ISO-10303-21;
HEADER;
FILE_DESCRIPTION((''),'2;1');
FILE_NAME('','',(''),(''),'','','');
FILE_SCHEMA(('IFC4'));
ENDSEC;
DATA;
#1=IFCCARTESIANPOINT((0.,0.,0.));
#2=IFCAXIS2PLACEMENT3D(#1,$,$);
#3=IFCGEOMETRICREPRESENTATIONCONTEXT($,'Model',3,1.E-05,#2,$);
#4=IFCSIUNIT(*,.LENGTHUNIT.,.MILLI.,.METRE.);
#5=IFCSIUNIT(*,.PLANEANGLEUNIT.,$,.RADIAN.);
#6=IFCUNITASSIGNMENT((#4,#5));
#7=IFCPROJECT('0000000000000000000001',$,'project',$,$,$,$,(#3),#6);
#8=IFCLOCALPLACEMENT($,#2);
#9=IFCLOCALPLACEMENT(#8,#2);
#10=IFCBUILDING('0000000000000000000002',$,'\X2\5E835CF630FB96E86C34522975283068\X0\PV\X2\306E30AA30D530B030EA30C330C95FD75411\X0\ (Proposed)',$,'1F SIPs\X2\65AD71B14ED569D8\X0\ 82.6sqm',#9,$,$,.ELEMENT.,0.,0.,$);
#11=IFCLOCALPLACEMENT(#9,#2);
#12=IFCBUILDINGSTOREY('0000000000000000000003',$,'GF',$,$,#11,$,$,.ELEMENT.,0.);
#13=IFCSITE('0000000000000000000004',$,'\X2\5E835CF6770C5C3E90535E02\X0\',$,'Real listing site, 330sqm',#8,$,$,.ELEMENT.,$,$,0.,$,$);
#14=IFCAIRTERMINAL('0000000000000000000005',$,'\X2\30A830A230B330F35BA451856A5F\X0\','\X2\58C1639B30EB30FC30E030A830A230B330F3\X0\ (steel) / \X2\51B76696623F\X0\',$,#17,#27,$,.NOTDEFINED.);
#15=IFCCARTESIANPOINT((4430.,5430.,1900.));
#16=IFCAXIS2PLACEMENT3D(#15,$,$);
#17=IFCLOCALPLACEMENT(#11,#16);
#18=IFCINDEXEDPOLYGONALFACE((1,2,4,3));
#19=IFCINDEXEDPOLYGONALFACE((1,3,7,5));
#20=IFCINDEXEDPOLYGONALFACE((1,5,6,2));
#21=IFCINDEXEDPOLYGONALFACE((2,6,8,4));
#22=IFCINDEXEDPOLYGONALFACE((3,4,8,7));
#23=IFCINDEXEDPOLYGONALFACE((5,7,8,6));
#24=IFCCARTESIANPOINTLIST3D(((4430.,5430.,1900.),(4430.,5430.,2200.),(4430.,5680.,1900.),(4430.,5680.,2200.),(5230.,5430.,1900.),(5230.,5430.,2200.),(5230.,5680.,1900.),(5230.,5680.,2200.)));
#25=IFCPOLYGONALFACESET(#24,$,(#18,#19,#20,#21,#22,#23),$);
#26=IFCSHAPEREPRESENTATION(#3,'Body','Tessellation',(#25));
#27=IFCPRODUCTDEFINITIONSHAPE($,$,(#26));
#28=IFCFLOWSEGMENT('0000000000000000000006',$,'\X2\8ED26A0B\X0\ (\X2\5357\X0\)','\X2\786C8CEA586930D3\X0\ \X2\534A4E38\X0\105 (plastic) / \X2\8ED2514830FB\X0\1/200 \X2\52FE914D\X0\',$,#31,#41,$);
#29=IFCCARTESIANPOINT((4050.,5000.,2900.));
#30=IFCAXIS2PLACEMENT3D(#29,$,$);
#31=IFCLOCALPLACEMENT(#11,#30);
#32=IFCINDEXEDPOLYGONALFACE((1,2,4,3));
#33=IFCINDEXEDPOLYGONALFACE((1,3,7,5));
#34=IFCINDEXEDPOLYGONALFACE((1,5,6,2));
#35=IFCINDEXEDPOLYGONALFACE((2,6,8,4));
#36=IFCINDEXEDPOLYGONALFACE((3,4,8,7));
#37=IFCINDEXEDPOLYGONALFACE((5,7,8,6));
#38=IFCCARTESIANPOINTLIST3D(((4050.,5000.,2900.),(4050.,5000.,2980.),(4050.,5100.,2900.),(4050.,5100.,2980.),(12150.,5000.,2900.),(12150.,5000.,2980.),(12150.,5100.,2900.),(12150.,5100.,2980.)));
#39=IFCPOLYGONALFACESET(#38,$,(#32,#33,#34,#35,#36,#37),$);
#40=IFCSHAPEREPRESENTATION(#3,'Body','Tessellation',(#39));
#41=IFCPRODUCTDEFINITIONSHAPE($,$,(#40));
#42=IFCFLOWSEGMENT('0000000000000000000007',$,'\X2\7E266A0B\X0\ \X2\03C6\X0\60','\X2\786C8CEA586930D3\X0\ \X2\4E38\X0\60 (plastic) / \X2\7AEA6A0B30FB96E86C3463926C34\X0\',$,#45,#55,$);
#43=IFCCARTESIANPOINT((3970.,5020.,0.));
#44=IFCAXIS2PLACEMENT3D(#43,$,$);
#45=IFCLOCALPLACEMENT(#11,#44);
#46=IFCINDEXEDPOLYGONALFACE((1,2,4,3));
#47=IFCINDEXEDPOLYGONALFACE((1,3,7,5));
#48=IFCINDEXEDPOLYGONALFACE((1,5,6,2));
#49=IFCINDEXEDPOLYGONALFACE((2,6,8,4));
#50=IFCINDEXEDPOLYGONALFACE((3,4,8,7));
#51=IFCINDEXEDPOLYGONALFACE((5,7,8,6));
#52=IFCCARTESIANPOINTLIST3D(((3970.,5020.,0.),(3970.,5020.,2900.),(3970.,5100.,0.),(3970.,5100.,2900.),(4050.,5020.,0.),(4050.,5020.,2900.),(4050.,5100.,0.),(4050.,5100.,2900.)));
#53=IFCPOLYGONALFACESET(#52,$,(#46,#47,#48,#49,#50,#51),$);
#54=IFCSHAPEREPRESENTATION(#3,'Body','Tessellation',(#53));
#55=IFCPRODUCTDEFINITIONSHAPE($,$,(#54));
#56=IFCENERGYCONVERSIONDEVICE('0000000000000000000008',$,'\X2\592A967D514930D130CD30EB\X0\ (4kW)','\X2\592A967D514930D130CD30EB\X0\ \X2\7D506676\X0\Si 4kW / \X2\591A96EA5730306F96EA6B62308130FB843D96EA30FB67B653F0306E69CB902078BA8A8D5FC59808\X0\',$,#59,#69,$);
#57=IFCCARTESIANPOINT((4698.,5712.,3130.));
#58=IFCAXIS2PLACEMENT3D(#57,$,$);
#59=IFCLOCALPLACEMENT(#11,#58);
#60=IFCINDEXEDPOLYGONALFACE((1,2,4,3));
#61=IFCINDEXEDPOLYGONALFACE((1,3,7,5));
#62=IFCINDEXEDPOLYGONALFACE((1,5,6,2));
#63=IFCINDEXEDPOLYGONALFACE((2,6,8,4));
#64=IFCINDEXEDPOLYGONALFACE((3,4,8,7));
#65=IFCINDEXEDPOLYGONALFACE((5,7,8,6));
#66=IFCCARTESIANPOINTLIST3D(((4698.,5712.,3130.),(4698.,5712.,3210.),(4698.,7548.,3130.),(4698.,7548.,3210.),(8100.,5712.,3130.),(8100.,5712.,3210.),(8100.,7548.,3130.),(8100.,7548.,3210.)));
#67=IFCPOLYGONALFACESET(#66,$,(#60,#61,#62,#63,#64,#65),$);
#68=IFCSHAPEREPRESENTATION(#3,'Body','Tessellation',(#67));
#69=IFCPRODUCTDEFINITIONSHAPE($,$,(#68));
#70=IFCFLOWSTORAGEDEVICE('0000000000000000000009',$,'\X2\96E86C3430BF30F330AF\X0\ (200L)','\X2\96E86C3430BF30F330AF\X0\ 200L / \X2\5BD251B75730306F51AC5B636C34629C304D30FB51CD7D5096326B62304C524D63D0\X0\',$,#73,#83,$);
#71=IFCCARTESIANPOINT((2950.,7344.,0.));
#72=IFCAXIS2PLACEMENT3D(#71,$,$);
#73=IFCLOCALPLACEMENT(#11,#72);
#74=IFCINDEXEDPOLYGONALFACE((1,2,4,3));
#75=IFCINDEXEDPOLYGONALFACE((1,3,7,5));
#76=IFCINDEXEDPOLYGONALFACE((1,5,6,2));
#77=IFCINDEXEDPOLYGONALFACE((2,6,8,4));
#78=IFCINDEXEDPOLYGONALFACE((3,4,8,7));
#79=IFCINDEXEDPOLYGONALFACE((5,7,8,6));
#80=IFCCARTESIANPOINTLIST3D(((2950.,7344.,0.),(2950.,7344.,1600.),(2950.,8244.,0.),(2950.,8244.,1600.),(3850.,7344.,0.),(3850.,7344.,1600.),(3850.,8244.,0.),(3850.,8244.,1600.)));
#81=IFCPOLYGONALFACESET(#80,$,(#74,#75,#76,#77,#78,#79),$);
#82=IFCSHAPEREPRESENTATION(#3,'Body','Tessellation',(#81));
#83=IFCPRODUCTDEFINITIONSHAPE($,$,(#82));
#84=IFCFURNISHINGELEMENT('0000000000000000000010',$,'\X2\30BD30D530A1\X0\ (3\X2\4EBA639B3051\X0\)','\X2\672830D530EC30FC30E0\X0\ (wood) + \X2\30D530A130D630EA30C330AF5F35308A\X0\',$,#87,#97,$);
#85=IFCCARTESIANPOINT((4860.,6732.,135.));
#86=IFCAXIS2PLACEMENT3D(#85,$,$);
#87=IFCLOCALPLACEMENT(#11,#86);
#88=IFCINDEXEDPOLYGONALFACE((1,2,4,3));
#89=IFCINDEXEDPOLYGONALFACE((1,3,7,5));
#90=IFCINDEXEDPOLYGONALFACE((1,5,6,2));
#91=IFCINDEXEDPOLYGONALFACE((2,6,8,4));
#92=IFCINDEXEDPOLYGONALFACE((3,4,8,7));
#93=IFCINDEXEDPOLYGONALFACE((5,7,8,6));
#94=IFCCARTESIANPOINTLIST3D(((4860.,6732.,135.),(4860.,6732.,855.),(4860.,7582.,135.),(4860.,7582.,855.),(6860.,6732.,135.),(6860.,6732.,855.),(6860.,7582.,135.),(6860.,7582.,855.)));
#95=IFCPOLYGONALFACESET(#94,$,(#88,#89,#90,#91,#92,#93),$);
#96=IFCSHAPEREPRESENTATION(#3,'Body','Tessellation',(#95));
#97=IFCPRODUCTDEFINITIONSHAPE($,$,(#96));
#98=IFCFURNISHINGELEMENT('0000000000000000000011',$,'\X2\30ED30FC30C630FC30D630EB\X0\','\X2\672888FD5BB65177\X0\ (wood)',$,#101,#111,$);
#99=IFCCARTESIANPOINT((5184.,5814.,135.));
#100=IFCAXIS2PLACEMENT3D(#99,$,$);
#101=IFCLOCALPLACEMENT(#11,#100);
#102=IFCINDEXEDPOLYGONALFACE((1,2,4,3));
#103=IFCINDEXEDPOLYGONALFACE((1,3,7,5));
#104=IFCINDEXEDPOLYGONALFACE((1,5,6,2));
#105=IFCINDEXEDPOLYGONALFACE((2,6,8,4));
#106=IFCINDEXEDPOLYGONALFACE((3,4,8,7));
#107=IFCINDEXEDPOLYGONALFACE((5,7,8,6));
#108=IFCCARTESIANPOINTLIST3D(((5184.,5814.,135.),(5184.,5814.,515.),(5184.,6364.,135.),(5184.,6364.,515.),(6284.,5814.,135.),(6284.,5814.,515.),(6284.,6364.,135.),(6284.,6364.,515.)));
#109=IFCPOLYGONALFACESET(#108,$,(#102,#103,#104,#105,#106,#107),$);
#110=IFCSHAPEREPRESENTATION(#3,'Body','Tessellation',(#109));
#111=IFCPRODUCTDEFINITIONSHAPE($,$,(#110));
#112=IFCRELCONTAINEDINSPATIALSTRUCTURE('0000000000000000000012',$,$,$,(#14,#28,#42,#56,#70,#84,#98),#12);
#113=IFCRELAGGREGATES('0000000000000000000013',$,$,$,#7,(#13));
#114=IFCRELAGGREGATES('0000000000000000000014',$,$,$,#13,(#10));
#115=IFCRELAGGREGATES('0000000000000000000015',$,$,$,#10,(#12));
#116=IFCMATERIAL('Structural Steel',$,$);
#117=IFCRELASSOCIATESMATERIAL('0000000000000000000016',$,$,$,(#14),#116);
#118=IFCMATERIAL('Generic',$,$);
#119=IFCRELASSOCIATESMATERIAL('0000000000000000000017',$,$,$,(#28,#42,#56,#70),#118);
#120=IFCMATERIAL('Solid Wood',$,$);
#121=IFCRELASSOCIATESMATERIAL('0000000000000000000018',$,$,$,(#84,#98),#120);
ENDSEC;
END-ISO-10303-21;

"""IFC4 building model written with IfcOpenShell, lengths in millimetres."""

from ifc_helpers import new_model, si_unit, frame, frame_2d, origin, place, context, project, spatial, rectangle, extrude, material, element, save


model = new_model("IFC4")

# Units and contexts
model_context = context("Model", 3, precision=1e-05, world=origin())
ifc_project = project(units=[si_unit("LENGTHUNIT", "METRE", prefix="MILLI"), si_unit("PLANEANGLEUNIT", "RADIAN")], contexts=[model_context])

# Site, building, storey
site_placement = place(None, origin())
site = spatial("IfcSite", under=ifc_project, at=site_placement, Name="広島県尾道市", ObjectType="Real listing site, 330sqm", CompositionType="ELEMENT", RefElevation=0.0)
building_placement = place(site_placement, origin())
building = spatial("IfcBuilding", under=site, at=building_placement, Name="広島・雨水利用とPVのオフグリッド志向 (Proposed)", ObjectType="1F SIPs断熱仕様 82.6sqm", CompositionType="ELEMENT", ElevationOfRefHeight=0.0, ElevationOfTerrain=0.0)
storey_placement = place(building_placement, origin())
storey = spatial("IfcBuildingStorey", under=building, at=storey_placement, Name="GF", CompositionType="ELEMENT", Elevation=0.0)

# Shared definitions
ifc_material_1 = material(Name="Solid Wood")

# Shared definitions
ifc_material_2 = material(Name="Structural Steel")

# Shared definitions
ifc_material_3 = material(Name="Generic")

# Air terminal
air_terminal_placement = place(storey_placement, frame((4430.0, 5430.0, 1900.0)))
element("IfcAirTerminal", 1, at=air_terminal_placement, inside=storey, material=ifc_material_2, Name="エアコン室内機", Description="壁掛ルームエアコン (steel) / 冷暖房", PredefinedType="NOTDEFINED", context=model_context, shape_type="SweptSolid", body=[
    extrude(rectangle(XDim=800.0, YDim=250.0, at=frame_2d((400.0, 125.0))), frame((4430.0, 5430.0, 1900.0)), (0.0, 0.0, 1.0), 300.0),
])

# Flow segments
flow_segment_1_placement = place(storey_placement, frame((4050.0, 5000.0, 2900.0)))
element("IfcFlowSegment", 2, at=flow_segment_1_placement, inside=storey, material=ifc_material_3, Name="軒樋 (南)", Description="硬質塩ビ 半丸105 (plastic) / 軒先・1/200 勾配", context=model_context, shape_type="SweptSolid", body=[
    extrude(rectangle(XDim=8100.0, YDim=100.0, at=frame_2d((4050.0, 50.0))), frame((4050.0, 5000.0, 2900.0)), (0.0, 0.0, 1.0), 80.0),
])
flow_segment_2_placement = place(storey_placement, frame((3970.0, 5020.0, 0.0)))
element("IfcFlowSegment", 3, at=flow_segment_2_placement, inside=storey, material=ifc_material_3, Name="縦樋 φ60", Description="硬質塩ビ 丸60 (plastic) / 竪樋・雨水排水", context=model_context, shape_type="SweptSolid", body=[
    extrude(rectangle(XDim=80.0, YDim=80.0, at=frame_2d((40.0, 40.0))), frame((3970.0, 5020.0, 0.0)), (0.0, 0.0, 1.0), 2900.0),
])

# Energy conversion device
energy_conversion_device_placement = place(storey_placement, frame((4698.0, 5712.0, 3130.0)))
element("IfcEnergyConversionDevice", 4, at=energy_conversion_device_placement, inside=storey, material=ifc_material_3, Name="太陽光パネル (4kW)", Description="太陽光パネル 結晶Si 4kW / 多雪地は雪止め・落雪・架台の構造確認必須", context=model_context, shape_type="SweptSolid", body=[
    extrude(rectangle(XDim=3402.0, YDim=1836.0, at=frame_2d((1701.0, 918.0))), frame((4698.0, 5712.0, 3130.0)), (0.0, 0.0, 1.0), 80.0),
])

# Flow storage device
flow_storage_device_placement = place(storey_placement, frame((2950.0, 7344.0, 0.0)))
element("IfcFlowStorageDevice", 5, at=flow_storage_device_placement, inside=storey, material=ifc_material_3, Name="雨水タンク (200L)", Description="雨水タンク 200L / 寒冷地は冬季水抜き・凍結防止が前提", context=model_context, shape_type="SweptSolid", body=[
    extrude(rectangle(XDim=900.0, YDim=900.0, at=frame_2d((450.0, 450.0))), frame((2950.0, 7344.0, 0.0)), (0.0, 0.0, 1.0), 1600.0),
])

# Furnishing elements
furnishing_1_placement = place(storey_placement, frame((4860.0, 6732.0, 135.0)))
element("IfcFurnishingElement", 6, at=furnishing_1_placement, inside=storey, material=ifc_material_1, Name="ソファ (3人掛け)", Description="木フレーム (wood) + ファブリック張り", context=model_context, shape_type="SweptSolid", body=[
    extrude(rectangle(XDim=2000.0, YDim=850.0, at=frame_2d((1000.0, 425.0))), frame((4860.0, 6732.0, 135.0)), (0.0, 0.0, 1.0), 720.0),
])
furnishing_2_placement = place(storey_placement, frame((5184.0, 5814.0, 135.0)))
element("IfcFurnishingElement", 7, at=furnishing_2_placement, inside=storey, material=ifc_material_1, Name="ローテーブル", Description="木製家具 (wood)", context=model_context, shape_type="SweptSolid", body=[
    extrude(rectangle(XDim=1100.0, YDim=550.0, at=frame_2d((550.0, 275.0))), frame((5184.0, 5814.0, 135.0)), (0.0, 0.0, 1.0), 380.0),
])

save(model, "model.ifc")
